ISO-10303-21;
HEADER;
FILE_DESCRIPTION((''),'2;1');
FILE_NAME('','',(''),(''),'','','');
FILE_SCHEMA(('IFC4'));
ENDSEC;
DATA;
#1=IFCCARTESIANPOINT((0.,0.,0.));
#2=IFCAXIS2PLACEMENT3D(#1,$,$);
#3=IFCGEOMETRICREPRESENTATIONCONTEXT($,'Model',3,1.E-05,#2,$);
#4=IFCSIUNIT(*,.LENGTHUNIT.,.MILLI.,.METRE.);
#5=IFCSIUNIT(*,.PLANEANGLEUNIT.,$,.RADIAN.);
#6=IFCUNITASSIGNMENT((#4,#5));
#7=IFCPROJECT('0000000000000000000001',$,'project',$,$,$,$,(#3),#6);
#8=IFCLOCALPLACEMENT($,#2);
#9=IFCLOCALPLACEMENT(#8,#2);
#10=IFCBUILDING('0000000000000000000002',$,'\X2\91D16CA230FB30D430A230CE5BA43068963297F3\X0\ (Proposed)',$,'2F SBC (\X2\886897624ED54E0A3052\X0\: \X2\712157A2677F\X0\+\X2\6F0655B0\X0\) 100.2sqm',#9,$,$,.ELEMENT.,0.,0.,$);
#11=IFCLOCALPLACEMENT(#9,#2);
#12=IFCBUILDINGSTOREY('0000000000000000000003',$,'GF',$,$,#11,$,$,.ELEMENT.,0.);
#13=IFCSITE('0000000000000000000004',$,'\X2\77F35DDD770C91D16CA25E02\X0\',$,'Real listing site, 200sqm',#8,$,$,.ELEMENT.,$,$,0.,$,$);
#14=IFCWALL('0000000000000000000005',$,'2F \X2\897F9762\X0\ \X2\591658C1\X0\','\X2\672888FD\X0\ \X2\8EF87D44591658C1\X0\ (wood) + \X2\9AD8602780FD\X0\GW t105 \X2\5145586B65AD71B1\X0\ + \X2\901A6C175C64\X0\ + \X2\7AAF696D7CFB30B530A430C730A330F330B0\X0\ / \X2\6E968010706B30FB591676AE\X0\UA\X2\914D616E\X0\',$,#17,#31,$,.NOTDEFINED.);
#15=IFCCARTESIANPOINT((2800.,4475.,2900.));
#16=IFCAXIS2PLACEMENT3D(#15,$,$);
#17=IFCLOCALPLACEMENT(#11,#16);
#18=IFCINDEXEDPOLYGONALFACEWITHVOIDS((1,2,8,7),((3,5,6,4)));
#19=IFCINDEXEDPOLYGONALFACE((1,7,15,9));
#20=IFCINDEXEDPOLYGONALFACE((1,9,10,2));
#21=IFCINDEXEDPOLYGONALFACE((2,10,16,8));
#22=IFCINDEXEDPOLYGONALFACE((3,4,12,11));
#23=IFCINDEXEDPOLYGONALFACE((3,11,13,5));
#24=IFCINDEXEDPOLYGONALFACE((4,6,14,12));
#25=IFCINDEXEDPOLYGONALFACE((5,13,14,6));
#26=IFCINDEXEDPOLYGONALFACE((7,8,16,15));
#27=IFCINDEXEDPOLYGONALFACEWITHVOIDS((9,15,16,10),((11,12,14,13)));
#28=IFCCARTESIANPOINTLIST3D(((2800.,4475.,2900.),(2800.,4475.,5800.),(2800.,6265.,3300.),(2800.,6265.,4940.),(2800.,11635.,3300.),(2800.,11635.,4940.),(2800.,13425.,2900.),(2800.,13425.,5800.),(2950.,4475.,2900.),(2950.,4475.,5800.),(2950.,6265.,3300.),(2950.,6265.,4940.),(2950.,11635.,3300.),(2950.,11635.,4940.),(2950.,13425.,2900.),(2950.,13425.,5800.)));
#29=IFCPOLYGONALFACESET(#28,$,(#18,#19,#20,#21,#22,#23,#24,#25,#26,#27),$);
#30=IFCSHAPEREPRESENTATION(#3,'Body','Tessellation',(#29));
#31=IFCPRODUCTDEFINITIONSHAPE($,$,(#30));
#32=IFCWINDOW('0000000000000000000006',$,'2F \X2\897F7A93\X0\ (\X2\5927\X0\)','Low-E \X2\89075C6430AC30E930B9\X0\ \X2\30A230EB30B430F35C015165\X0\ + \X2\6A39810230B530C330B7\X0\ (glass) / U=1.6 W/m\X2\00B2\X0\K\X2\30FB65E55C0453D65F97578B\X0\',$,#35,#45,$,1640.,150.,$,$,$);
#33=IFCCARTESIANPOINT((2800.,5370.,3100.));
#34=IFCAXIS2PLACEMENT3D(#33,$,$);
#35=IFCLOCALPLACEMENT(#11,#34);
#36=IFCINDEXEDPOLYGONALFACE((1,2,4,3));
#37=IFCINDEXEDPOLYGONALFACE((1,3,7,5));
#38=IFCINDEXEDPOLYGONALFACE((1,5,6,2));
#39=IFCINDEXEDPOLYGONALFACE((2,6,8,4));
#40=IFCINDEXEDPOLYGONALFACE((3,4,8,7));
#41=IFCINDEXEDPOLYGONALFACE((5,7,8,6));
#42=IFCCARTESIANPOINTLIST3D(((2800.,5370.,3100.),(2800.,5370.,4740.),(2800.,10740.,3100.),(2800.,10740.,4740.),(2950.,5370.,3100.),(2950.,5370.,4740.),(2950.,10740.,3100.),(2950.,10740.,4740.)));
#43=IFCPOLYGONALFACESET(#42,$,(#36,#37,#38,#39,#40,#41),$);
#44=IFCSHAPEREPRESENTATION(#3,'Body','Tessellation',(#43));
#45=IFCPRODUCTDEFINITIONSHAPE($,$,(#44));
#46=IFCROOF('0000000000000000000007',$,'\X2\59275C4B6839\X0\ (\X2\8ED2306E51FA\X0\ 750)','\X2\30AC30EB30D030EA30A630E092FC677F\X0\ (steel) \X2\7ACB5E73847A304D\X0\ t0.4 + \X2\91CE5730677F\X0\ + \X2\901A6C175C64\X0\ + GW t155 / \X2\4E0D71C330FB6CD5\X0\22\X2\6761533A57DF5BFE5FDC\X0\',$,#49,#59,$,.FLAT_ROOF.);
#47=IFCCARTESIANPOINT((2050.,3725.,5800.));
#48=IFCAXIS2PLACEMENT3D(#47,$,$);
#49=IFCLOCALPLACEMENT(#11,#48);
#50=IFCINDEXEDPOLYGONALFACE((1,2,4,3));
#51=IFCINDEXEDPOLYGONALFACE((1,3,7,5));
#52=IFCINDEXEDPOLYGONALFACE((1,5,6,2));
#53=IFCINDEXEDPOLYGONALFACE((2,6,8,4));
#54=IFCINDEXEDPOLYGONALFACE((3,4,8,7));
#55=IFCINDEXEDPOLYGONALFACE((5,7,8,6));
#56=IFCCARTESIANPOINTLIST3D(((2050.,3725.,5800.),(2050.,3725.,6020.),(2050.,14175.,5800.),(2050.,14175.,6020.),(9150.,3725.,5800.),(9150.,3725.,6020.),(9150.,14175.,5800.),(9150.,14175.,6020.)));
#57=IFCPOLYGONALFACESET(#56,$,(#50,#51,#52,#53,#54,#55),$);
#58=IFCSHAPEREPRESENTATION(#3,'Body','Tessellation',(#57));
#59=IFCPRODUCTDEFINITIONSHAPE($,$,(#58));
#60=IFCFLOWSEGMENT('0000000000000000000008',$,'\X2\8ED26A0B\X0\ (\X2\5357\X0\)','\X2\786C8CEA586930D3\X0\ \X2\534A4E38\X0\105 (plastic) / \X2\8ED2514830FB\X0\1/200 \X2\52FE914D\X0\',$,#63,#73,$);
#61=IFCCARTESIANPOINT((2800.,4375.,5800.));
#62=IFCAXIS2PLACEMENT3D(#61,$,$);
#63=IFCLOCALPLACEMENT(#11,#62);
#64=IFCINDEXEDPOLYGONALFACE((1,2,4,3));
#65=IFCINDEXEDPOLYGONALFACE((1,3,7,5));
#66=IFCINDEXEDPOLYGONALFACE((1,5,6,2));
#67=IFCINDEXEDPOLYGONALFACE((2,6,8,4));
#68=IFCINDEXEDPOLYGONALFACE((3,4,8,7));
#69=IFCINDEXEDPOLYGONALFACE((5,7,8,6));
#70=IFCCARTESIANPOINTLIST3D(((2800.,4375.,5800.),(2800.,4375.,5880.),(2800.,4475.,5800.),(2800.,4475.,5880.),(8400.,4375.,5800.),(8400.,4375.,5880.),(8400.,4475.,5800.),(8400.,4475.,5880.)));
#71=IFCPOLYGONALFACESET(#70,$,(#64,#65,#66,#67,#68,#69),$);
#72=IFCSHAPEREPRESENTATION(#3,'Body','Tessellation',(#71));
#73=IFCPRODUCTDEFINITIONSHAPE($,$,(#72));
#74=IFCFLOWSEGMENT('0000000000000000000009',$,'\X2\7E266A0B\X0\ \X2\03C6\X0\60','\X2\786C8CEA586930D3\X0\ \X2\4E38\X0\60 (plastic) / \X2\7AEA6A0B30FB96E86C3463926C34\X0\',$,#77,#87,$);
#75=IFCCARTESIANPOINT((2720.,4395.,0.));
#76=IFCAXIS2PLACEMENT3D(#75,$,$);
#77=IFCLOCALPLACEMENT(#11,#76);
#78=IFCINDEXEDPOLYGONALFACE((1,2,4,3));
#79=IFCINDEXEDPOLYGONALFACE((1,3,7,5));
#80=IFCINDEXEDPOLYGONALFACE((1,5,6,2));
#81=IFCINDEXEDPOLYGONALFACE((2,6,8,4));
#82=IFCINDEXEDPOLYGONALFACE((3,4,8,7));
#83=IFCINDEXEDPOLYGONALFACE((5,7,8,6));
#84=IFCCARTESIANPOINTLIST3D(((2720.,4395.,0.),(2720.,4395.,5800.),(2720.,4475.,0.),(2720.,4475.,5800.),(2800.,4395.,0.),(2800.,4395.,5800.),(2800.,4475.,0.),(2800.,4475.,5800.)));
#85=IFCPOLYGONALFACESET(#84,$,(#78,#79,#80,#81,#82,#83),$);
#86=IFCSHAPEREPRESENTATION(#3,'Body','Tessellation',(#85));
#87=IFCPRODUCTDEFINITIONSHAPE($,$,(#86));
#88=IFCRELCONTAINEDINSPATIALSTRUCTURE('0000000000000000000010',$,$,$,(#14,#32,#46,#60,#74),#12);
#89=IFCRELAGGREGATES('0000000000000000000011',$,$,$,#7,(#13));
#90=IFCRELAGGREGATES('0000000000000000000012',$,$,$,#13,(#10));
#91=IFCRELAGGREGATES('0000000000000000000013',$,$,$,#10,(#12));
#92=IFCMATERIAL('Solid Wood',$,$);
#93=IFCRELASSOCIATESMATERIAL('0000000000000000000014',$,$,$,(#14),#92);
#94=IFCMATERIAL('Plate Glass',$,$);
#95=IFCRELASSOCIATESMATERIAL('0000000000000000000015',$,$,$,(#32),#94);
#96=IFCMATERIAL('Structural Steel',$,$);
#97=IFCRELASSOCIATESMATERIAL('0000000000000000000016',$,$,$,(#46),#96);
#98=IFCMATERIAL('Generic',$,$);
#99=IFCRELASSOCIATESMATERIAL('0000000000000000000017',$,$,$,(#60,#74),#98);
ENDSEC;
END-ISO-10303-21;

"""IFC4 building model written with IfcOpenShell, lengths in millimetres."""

from ifc_helpers import new_model, si_unit, frame, frame_2d, origin, place, context, project, spatial, rectangle, extrude, material, element, fill, save


model = new_model("IFC4")

# Units and contexts
model_context = context("Model", 3, precision=1e-05, world=origin())
ifc_project = project(units=[si_unit("LENGTHUNIT", "METRE", prefix="MILLI"), si_unit("PLANEANGLEUNIT", "RADIAN")], contexts=[model_context])

# Site, building, storey
site_placement = place(None, origin())
site = spatial("IfcSite", under=ifc_project, at=site_placement, Name="石川県金沢市", ObjectType="Real listing site, 200sqm", CompositionType="ELEMENT", RefElevation=0.0)
building_placement = place(site_placement, origin())
building = spatial("IfcBuilding", under=site, at=building_placement, Name="金沢・ピアノ室と防音 (Proposed)", ObjectType="2F SBC (表面仕上げ: 無垢板+漆喰) 100.2sqm", CompositionType="ELEMENT", ElevationOfRefHeight=0.0, ElevationOfTerrain=0.0)
storey_placement = place(building_placement, origin())
storey = spatial("IfcBuildingStorey", under=building, at=storey_placement, Name="GF", CompositionType="ELEMENT", Elevation=0.0)

# Shared definitions
ifc_material_1 = material(Name="Solid Wood")

# Shared definitions
ifc_material_2 = material(Name="Plate Glass")

# Wall, opening, window
wall_1_placement = place(storey_placement, frame((2800.0, 4475.0, 2900.0)))
wall_1 = element("IfcWall", 1, at=wall_1_placement, inside=storey, material=ifc_material_1, Name="2F 西面 外壁", Description="木製 軸組外壁 (wood) + 高性能GW t105 充填断熱 + 通気層 + 窯業系サイディング / 準耐火・外皮UA配慮", PredefinedType="NOTDEFINED", context=model_context, shape_type="SweptSolid", body=[
    extrude(rectangle(XDim=150.0, YDim=8950.0, at=frame_2d((75.0, 4475.0))), frame((2800.0, 4475.0, 2900.0)), (0.0, 0.0, 1.0), 2900.0),
])
opening_1_placement = place(storey_placement, frame((2800.0, 5370.0, 3100.0)))
opening_1 = element("IfcOpeningElement", 2, at=opening_1_placement, cuts=wall_1, PredefinedType="NOTDEFINED", context=model_context, shape_type="SweptSolid", body=[
    extrude(rectangle(XDim=150.0, YDim=5370.0, at=frame_2d((75.0, 2685.0))), frame((2800.0, 5370.0, 3100.0)), (0.0, 0.0, 1.0), 1640.0),
])
window_1_placement = place(storey_placement, frame((2800.0, 5370.0, 3100.0)))
window_1 = element("IfcWindow", 3, at=window_1_placement, inside=storey, material=ifc_material_2, Name="2F 西窓 (大)", Description="Low-E 複層ガラス アルゴン封入 + 樹脂サッシ (glass) / U=1.6 W/m²K・日射取得型", OverallHeight=1640.0, OverallWidth=150.0, context=model_context, shape_type="SweptSolid", body=[
    extrude(rectangle(XDim=150.0, YDim=5370.0, at=frame_2d((75.0, 2685.0))), frame((2800.0, 5370.0, 3100.0)), (0.0, 0.0, 1.0), 1640.0),
])
fill(opening_1, window_1)

# Roof
ifc_material_3 = material(Name="Structural Steel")
roof_placement = place(storey_placement, frame((2050.0, 3725.0, 5800.0)))
element("IfcRoof", 4, at=roof_placement, inside=storey, material=ifc_material_3, Name="大屋根 (軒の出 750)", Description="ガルバリウム鋼板 (steel) 立平葺き t0.4 + 野地板 + 通気層 + GW t155 / 不燃・法22条区域対応", PredefinedType="FLAT_ROOF", context=model_context, shape_type="SweptSolid", body=[
    extrude(rectangle(XDim=7100.0, YDim=10450.0, at=frame_2d((3550.0, 5225.0))), frame((2050.0, 3725.0, 5800.0)), (0.0, 0.0, 1.0), 220.0),
])

# Flow segments
ifc_material_4 = material(Name="Generic")
flow_segment_1_placement = place(storey_placement, frame((2800.0, 4375.0, 5800.0)))
element("IfcFlowSegment", 5, at=flow_segment_1_placement, inside=storey, material=ifc_material_4, Name="軒樋 (南)", Description="硬質塩ビ 半丸105 (plastic) / 軒先・1/200 勾配", context=model_context, shape_type="SweptSolid", body=[
    extrude(rectangle(XDim=5600.0, YDim=100.0, at=frame_2d((2800.0, 50.0))), frame((2800.0, 4375.0, 5800.0)), (0.0, 0.0, 1.0), 80.0),
])
flow_segment_2_placement = place(storey_placement, frame((2720.0, 4395.0, 0.0)))
element("IfcFlowSegment", 6, at=flow_segment_2_placement, inside=storey, material=ifc_material_4, Name="縦樋 φ60", Description="硬質塩ビ 丸60 (plastic) / 竪樋・雨水排水", context=model_context, shape_type="SweptSolid", body=[
    extrude(rectangle(XDim=80.0, YDim=80.0, at=frame_2d((40.0, 40.0))), frame((2720.0, 4395.0, 0.0)), (0.0, 0.0, 1.0), 5800.0),
])

save(model, "model.ifc")
